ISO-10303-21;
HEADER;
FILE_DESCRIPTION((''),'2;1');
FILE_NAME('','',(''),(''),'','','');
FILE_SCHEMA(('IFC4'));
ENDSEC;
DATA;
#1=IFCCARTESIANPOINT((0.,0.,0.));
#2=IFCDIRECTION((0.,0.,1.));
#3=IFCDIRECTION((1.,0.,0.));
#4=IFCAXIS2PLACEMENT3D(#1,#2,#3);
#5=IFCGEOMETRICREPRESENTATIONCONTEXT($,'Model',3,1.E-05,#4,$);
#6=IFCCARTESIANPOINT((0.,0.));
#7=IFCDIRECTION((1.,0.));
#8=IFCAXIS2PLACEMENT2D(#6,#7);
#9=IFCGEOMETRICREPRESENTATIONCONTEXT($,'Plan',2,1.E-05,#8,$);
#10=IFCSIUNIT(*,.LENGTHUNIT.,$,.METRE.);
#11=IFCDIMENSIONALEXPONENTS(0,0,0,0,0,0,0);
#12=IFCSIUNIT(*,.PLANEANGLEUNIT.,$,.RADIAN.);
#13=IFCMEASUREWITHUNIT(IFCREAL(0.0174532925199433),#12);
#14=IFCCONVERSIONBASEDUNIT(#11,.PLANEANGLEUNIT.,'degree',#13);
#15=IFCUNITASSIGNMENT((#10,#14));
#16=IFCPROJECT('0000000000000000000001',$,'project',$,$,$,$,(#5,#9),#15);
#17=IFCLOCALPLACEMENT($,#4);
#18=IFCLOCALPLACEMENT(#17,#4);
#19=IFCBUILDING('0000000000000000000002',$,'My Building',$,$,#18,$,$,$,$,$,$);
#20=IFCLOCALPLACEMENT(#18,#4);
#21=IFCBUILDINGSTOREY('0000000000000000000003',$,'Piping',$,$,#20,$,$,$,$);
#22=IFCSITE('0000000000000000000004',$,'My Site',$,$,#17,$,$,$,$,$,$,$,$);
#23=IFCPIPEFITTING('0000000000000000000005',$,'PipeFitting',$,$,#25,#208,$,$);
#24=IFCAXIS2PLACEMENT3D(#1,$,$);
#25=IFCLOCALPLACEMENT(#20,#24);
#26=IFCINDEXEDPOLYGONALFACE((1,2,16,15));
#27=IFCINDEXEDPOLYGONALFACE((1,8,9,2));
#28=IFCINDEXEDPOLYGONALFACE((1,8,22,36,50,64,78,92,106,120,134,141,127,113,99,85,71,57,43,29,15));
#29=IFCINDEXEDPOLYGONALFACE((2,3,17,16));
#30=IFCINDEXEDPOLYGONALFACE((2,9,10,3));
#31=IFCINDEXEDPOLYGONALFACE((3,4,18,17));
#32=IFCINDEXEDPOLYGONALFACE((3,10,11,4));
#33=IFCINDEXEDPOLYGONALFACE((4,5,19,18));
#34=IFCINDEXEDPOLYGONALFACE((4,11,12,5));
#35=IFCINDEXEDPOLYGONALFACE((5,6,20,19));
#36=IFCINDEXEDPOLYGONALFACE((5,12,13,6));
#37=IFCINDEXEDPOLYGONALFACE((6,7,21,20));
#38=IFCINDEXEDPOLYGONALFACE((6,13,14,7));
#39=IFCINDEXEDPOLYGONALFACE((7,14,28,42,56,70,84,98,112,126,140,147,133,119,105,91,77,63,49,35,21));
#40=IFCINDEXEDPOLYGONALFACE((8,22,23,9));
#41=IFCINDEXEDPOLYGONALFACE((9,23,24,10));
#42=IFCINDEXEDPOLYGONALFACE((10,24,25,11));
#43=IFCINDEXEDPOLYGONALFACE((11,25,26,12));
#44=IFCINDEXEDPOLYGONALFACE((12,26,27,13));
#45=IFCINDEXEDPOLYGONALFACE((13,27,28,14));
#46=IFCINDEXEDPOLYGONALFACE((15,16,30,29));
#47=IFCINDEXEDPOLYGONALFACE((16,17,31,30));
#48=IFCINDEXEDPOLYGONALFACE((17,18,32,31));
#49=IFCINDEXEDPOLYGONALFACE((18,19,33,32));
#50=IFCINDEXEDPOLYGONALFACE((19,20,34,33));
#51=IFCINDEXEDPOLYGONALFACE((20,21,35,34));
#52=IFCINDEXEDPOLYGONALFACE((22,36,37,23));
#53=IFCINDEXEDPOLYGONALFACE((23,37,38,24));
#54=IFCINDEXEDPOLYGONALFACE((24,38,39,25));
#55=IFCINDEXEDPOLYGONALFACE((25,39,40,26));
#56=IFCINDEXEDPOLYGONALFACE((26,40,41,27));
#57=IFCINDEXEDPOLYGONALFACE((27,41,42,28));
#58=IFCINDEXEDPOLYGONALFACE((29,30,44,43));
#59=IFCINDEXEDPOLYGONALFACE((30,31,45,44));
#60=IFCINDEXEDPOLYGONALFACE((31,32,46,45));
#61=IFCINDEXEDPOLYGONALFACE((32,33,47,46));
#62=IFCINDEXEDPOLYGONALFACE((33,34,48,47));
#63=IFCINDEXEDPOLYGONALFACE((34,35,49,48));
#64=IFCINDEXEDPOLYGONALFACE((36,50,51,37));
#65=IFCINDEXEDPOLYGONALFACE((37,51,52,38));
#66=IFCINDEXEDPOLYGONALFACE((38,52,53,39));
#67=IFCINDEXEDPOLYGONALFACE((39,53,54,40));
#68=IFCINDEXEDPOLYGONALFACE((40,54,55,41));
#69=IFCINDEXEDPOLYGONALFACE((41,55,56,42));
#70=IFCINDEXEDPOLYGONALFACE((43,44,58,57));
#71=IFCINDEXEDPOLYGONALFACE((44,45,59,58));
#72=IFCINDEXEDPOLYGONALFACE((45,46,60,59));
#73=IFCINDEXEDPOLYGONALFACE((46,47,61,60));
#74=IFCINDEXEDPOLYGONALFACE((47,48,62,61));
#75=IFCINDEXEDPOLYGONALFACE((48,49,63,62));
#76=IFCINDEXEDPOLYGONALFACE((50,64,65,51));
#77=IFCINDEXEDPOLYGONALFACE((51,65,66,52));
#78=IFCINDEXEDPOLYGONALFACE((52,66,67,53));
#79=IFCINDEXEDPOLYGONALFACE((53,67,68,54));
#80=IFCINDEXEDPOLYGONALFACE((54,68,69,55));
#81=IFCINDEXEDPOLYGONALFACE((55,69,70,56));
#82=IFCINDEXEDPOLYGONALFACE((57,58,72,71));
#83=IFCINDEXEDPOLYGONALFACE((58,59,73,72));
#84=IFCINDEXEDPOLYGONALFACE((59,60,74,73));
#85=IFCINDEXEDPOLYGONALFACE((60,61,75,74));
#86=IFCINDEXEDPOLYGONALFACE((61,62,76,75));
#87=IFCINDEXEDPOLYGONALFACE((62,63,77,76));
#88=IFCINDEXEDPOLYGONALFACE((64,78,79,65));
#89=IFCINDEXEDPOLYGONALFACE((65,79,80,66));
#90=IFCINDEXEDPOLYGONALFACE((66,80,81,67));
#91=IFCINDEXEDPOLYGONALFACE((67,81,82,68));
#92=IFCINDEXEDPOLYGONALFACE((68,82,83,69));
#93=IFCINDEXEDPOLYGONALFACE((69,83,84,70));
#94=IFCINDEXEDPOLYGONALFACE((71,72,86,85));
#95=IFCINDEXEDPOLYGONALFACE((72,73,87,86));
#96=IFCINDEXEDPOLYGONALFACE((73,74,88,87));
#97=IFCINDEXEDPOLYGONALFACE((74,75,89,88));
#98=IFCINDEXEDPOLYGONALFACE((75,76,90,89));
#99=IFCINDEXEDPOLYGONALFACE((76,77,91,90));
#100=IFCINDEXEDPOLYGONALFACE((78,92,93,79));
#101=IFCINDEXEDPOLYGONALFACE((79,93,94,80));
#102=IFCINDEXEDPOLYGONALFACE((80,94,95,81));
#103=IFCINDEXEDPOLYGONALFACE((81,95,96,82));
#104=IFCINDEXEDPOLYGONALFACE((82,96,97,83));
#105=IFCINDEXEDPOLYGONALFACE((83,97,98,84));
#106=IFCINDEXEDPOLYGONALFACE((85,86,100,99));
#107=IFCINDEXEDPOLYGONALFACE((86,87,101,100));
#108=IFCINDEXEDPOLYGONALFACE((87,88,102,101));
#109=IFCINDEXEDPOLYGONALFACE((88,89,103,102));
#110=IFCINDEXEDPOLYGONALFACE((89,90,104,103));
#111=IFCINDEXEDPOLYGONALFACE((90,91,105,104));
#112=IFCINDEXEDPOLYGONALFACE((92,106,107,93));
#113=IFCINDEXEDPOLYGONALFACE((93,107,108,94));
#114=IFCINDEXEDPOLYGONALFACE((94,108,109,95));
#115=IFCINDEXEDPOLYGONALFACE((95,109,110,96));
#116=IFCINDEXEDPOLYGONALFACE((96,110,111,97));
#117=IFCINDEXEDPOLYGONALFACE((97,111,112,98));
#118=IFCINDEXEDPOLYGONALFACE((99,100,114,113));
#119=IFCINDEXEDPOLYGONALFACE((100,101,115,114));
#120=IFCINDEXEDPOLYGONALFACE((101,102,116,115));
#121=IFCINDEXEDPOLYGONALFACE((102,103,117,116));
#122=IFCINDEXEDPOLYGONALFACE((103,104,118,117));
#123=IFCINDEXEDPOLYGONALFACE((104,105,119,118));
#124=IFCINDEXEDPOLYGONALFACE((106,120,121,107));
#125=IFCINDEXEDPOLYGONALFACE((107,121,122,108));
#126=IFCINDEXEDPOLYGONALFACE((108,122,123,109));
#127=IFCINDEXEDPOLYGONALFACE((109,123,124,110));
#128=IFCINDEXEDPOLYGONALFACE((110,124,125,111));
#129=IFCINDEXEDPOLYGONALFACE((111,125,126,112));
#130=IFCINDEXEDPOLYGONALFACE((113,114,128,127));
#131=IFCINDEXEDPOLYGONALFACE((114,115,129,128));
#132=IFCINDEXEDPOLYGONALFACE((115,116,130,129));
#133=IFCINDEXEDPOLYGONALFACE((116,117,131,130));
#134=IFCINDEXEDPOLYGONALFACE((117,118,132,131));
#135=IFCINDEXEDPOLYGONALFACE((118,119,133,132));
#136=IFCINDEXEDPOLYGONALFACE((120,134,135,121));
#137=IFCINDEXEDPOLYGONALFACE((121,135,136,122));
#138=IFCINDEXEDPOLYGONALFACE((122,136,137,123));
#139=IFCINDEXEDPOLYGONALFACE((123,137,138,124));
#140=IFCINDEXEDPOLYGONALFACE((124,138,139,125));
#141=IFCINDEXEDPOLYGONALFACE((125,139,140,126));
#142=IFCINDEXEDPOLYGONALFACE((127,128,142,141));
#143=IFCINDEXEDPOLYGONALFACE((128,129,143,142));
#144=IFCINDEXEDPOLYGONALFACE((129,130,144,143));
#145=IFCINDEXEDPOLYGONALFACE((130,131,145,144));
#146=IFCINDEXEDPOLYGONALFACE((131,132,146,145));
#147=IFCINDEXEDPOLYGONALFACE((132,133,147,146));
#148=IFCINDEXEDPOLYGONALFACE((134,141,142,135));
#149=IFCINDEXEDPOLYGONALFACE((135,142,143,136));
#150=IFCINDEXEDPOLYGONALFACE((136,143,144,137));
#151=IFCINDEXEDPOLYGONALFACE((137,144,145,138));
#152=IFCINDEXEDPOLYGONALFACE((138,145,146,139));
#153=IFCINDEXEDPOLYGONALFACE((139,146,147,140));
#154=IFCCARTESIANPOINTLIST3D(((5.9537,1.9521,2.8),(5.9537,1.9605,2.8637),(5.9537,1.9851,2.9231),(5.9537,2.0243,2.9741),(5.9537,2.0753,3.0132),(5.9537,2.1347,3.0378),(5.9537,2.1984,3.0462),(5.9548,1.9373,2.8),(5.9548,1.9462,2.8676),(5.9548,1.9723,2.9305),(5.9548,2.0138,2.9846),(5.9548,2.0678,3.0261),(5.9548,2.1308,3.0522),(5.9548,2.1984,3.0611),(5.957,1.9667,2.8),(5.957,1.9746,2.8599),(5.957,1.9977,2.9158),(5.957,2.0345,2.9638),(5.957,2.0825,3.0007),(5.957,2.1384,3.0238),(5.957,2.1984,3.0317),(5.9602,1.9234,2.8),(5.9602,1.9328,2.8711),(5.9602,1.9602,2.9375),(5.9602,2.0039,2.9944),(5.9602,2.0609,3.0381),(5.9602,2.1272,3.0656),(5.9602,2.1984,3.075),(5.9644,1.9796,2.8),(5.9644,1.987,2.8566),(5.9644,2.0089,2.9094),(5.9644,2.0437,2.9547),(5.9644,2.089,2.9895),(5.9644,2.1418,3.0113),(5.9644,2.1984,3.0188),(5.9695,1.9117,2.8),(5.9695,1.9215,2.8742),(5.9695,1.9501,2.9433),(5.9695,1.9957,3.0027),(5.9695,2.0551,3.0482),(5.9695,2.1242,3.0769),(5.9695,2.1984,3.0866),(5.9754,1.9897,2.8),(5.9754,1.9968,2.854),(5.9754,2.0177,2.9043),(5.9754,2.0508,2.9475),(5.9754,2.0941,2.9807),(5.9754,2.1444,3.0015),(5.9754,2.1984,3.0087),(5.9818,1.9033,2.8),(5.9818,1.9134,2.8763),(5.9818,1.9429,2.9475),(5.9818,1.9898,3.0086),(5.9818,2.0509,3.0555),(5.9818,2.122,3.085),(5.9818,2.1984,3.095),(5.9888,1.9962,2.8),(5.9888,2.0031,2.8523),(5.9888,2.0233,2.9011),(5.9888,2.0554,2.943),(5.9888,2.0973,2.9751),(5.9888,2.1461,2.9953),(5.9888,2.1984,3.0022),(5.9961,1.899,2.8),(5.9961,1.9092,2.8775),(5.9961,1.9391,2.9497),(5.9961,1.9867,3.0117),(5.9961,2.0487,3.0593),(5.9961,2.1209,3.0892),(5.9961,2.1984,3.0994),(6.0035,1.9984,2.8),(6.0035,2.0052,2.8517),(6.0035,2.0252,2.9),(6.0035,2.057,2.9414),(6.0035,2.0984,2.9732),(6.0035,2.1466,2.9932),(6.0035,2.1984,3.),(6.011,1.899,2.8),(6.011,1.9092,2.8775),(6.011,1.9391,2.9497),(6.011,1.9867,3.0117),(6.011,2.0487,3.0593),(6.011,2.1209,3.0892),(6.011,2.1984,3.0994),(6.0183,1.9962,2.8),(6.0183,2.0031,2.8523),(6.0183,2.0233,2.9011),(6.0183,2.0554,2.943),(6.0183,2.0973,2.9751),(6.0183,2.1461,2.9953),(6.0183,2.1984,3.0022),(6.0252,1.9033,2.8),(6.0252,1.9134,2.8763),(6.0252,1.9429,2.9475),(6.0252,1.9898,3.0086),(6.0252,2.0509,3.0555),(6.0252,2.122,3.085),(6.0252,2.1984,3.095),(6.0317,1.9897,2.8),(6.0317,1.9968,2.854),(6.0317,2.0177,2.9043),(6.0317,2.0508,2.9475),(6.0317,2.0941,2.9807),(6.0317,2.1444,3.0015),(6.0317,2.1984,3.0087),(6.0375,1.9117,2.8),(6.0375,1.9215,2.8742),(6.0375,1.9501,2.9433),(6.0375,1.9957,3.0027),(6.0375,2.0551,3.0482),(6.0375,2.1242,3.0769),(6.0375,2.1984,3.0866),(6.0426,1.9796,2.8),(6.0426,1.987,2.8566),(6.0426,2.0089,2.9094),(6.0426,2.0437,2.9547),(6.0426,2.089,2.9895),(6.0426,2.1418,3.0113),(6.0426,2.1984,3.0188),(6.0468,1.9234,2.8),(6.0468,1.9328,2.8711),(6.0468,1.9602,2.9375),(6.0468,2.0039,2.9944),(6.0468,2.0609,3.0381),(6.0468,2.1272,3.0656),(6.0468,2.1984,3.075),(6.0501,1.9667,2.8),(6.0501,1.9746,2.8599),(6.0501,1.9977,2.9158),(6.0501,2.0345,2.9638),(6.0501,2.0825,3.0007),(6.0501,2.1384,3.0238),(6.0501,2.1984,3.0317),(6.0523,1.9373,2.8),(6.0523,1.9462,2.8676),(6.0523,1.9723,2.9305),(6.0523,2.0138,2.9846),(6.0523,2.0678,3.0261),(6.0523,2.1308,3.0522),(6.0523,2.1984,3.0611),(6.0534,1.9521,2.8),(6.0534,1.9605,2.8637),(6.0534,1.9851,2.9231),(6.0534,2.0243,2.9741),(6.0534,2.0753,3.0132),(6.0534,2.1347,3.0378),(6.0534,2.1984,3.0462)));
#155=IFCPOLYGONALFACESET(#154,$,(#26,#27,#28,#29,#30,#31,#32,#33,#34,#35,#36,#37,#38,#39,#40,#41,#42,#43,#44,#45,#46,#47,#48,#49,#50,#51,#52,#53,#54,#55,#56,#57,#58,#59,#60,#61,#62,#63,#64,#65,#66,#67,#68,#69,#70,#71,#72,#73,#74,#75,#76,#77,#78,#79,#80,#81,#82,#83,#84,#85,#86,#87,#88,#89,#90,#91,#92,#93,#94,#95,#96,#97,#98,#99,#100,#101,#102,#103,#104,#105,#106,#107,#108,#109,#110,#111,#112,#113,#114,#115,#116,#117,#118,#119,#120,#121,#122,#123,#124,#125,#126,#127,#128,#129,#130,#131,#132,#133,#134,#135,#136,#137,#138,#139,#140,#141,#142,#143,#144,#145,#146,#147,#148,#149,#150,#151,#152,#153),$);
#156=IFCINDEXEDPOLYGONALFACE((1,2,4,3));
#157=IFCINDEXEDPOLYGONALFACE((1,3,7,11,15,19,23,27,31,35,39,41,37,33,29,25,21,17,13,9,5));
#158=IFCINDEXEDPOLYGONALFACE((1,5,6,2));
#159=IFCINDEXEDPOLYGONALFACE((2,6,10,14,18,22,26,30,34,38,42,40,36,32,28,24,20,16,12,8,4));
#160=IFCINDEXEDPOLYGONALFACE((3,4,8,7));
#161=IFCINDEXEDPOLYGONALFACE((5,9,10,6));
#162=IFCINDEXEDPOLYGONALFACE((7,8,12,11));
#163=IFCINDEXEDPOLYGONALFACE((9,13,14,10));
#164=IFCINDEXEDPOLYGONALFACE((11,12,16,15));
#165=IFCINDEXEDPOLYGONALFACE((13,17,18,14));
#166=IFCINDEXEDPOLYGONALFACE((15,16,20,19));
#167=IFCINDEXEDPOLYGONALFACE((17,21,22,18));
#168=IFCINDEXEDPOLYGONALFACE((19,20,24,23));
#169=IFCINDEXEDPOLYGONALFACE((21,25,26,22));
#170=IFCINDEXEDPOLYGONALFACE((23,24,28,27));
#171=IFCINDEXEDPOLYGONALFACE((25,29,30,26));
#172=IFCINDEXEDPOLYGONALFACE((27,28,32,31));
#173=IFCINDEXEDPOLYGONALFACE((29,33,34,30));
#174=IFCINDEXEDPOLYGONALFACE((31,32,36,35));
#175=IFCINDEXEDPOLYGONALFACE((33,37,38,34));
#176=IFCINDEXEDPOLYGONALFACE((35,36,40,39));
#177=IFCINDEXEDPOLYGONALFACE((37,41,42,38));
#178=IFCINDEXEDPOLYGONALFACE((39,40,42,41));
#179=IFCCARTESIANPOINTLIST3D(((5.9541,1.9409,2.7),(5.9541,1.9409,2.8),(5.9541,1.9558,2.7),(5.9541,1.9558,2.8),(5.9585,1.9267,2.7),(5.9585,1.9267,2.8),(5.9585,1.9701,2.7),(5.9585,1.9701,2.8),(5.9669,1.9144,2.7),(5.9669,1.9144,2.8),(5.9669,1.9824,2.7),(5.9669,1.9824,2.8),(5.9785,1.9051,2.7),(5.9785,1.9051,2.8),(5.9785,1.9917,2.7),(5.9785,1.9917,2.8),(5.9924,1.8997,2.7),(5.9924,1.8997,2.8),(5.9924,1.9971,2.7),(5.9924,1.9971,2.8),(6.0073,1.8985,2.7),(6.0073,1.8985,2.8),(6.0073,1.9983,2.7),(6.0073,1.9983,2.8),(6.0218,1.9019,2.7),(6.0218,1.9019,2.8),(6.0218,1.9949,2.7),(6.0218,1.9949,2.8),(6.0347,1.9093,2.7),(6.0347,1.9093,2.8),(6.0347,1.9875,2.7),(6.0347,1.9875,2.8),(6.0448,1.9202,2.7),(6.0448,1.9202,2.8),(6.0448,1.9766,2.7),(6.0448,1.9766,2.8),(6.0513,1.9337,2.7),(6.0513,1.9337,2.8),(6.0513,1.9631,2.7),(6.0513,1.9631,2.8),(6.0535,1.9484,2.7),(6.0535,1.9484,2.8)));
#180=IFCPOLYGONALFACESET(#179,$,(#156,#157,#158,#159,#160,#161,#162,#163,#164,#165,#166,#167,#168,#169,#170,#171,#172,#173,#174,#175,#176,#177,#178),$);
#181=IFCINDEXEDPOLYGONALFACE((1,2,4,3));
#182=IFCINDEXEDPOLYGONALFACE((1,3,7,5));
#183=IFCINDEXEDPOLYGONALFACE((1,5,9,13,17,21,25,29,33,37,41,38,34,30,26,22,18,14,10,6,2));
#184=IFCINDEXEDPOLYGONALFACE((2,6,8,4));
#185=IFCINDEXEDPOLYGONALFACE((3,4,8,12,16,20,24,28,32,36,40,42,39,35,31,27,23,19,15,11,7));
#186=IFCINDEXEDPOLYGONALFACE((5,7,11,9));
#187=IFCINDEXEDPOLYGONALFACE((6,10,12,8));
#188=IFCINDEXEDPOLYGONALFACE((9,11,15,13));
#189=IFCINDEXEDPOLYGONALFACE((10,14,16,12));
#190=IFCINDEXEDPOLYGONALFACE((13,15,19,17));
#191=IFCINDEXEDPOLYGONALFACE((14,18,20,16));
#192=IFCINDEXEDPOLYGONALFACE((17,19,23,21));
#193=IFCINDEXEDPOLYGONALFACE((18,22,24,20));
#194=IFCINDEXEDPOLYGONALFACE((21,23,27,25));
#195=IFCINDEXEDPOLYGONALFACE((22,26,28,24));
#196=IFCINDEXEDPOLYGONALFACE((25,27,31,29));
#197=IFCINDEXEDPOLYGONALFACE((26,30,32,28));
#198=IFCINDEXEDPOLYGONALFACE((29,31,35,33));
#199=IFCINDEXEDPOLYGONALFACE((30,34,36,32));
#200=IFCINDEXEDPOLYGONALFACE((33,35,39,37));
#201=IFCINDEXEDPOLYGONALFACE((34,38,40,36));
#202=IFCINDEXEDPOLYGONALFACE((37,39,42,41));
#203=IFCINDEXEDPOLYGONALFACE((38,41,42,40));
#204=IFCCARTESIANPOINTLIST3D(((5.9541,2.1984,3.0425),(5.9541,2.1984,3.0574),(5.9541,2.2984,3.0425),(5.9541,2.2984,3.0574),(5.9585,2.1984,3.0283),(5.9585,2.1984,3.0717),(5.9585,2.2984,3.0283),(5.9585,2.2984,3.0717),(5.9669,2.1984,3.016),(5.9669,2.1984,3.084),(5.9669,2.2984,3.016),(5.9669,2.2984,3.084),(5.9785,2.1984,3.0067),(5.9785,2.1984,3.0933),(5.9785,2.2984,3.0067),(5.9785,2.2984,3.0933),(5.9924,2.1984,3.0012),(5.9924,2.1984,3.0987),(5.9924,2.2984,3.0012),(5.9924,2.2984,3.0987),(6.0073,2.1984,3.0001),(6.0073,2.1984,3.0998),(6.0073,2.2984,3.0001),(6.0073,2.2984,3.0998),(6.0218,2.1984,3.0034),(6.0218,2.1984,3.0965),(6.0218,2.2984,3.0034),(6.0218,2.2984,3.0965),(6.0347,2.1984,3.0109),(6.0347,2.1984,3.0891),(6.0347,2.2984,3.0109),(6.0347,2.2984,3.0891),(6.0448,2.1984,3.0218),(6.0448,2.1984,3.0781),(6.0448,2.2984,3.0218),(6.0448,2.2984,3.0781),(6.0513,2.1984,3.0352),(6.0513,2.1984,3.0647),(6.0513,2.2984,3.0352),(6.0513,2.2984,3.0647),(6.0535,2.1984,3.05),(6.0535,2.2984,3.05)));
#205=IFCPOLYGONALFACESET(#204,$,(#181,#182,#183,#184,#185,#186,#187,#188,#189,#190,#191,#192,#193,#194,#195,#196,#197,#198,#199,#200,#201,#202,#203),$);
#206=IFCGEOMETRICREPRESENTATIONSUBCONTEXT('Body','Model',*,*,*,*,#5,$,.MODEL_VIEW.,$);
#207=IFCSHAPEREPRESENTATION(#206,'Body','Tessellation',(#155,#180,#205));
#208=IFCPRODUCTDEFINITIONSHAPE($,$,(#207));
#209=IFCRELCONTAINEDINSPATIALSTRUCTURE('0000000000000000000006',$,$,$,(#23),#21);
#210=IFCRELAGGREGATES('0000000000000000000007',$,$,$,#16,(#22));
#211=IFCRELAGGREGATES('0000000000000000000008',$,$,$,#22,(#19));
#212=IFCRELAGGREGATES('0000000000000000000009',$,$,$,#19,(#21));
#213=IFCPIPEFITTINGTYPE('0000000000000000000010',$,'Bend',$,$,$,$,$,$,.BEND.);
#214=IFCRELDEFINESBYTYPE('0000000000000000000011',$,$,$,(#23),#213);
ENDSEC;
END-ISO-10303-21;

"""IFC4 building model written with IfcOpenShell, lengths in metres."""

from ifc_helpers import new_model, entity, si_unit, converted_unit, frame, origin_with_axes, origin_2d_with_axis, place, context, subcontext, project, spatial, circle, extrude, source, transform, mapped, type_object, type_shapes, element, save


model = new_model("IFC4")

# Units and contexts
model_context = context("Model", 3, precision=1e-05, world=origin_with_axes())
plan_context = context("Plan", 2, precision=1e-05, world=origin_2d_with_axis())
body_context = subcontext(model_context, "Body", "Model", "MODEL_VIEW")
ifc_project = project(units=[si_unit("LENGTHUNIT", "METRE"), converted_unit("PLANEANGLEUNIT", "degree", entity("IfcReal", 0.0174532925199433), si_unit("PLANEANGLEUNIT", "RADIAN"), dimensions=[0, 0, 0, 0, 0, 0, 0])], contexts=[model_context, plan_context])

# Site, building, storey
site_placement = place(None, origin_with_axes())
site = spatial("IfcSite", under=ifc_project, at=site_placement, Name="My Site")
building_placement = place(site_placement, origin_with_axes())
building = spatial("IfcBuilding", under=site, at=building_placement, Name="My Building")
storey_placement = place(building_placement, origin_with_axes())
storey = spatial("IfcBuildingStorey", under=building, at=storey_placement, Name="Piping")

# Pipe fitting
pipe_fitting_type_1 = type_object("IfcPipeFittingType", Name="Bend", PredefinedType="BEND")
shared_shape = source(origin_with_axes(), body_context, "Body", "SolidModel", [
    entity("IfcSweptDiskSolid", entity("IfcIndexedPolyCurve", entity("IfcCartesianPointList3D", [[0.0, 0.0, -0.1], [0.0, -0.0732, -0.2768], [0.0, -0.25, -0.35]]), [entity("IfcArcIndex", [1, 2, 3])]), 0.05),
    extrude(circle(Radius=0.05), origin_with_axes(), (0.0, 0.0, -1.0), 0.1),
    extrude(circle(Radius=0.05), frame((0.0, -0.25, -0.35), z_axis=(0.0, -1.0, 0.0), x_axis=(1.0, 0.0, 0.0)), (0.0, 0.0, 1.0), 0.1),
])
type_shapes(pipe_fitting_type_1, [shared_shape])
for number, where, z_axis, x_axis, name in (
    (1, (6.0035, 1.9484, 2.7), (0.0, 0.0, -1.0), (1.0, 0.0, 0.0), "PipeFitting"),
):
    element("IfcPipeFitting", number, at=place(storey_placement, frame(where, z_axis=z_axis, x_axis=x_axis)), inside=storey, type_object=pipe_fitting_type_1, Name=name, context=body_context, shape_type="MappedRepresentation", body=[
        mapped(shared_shape, transform((0.0, 0.0, 0.0), x_axis=(1.0, 0.0, 0.0), y_axis=(0.0, 1.0, 0.0), z_axis=(0.0, 0.0, 1.0), scale=1.0)),
    ])

save(model, "model.ifc")
